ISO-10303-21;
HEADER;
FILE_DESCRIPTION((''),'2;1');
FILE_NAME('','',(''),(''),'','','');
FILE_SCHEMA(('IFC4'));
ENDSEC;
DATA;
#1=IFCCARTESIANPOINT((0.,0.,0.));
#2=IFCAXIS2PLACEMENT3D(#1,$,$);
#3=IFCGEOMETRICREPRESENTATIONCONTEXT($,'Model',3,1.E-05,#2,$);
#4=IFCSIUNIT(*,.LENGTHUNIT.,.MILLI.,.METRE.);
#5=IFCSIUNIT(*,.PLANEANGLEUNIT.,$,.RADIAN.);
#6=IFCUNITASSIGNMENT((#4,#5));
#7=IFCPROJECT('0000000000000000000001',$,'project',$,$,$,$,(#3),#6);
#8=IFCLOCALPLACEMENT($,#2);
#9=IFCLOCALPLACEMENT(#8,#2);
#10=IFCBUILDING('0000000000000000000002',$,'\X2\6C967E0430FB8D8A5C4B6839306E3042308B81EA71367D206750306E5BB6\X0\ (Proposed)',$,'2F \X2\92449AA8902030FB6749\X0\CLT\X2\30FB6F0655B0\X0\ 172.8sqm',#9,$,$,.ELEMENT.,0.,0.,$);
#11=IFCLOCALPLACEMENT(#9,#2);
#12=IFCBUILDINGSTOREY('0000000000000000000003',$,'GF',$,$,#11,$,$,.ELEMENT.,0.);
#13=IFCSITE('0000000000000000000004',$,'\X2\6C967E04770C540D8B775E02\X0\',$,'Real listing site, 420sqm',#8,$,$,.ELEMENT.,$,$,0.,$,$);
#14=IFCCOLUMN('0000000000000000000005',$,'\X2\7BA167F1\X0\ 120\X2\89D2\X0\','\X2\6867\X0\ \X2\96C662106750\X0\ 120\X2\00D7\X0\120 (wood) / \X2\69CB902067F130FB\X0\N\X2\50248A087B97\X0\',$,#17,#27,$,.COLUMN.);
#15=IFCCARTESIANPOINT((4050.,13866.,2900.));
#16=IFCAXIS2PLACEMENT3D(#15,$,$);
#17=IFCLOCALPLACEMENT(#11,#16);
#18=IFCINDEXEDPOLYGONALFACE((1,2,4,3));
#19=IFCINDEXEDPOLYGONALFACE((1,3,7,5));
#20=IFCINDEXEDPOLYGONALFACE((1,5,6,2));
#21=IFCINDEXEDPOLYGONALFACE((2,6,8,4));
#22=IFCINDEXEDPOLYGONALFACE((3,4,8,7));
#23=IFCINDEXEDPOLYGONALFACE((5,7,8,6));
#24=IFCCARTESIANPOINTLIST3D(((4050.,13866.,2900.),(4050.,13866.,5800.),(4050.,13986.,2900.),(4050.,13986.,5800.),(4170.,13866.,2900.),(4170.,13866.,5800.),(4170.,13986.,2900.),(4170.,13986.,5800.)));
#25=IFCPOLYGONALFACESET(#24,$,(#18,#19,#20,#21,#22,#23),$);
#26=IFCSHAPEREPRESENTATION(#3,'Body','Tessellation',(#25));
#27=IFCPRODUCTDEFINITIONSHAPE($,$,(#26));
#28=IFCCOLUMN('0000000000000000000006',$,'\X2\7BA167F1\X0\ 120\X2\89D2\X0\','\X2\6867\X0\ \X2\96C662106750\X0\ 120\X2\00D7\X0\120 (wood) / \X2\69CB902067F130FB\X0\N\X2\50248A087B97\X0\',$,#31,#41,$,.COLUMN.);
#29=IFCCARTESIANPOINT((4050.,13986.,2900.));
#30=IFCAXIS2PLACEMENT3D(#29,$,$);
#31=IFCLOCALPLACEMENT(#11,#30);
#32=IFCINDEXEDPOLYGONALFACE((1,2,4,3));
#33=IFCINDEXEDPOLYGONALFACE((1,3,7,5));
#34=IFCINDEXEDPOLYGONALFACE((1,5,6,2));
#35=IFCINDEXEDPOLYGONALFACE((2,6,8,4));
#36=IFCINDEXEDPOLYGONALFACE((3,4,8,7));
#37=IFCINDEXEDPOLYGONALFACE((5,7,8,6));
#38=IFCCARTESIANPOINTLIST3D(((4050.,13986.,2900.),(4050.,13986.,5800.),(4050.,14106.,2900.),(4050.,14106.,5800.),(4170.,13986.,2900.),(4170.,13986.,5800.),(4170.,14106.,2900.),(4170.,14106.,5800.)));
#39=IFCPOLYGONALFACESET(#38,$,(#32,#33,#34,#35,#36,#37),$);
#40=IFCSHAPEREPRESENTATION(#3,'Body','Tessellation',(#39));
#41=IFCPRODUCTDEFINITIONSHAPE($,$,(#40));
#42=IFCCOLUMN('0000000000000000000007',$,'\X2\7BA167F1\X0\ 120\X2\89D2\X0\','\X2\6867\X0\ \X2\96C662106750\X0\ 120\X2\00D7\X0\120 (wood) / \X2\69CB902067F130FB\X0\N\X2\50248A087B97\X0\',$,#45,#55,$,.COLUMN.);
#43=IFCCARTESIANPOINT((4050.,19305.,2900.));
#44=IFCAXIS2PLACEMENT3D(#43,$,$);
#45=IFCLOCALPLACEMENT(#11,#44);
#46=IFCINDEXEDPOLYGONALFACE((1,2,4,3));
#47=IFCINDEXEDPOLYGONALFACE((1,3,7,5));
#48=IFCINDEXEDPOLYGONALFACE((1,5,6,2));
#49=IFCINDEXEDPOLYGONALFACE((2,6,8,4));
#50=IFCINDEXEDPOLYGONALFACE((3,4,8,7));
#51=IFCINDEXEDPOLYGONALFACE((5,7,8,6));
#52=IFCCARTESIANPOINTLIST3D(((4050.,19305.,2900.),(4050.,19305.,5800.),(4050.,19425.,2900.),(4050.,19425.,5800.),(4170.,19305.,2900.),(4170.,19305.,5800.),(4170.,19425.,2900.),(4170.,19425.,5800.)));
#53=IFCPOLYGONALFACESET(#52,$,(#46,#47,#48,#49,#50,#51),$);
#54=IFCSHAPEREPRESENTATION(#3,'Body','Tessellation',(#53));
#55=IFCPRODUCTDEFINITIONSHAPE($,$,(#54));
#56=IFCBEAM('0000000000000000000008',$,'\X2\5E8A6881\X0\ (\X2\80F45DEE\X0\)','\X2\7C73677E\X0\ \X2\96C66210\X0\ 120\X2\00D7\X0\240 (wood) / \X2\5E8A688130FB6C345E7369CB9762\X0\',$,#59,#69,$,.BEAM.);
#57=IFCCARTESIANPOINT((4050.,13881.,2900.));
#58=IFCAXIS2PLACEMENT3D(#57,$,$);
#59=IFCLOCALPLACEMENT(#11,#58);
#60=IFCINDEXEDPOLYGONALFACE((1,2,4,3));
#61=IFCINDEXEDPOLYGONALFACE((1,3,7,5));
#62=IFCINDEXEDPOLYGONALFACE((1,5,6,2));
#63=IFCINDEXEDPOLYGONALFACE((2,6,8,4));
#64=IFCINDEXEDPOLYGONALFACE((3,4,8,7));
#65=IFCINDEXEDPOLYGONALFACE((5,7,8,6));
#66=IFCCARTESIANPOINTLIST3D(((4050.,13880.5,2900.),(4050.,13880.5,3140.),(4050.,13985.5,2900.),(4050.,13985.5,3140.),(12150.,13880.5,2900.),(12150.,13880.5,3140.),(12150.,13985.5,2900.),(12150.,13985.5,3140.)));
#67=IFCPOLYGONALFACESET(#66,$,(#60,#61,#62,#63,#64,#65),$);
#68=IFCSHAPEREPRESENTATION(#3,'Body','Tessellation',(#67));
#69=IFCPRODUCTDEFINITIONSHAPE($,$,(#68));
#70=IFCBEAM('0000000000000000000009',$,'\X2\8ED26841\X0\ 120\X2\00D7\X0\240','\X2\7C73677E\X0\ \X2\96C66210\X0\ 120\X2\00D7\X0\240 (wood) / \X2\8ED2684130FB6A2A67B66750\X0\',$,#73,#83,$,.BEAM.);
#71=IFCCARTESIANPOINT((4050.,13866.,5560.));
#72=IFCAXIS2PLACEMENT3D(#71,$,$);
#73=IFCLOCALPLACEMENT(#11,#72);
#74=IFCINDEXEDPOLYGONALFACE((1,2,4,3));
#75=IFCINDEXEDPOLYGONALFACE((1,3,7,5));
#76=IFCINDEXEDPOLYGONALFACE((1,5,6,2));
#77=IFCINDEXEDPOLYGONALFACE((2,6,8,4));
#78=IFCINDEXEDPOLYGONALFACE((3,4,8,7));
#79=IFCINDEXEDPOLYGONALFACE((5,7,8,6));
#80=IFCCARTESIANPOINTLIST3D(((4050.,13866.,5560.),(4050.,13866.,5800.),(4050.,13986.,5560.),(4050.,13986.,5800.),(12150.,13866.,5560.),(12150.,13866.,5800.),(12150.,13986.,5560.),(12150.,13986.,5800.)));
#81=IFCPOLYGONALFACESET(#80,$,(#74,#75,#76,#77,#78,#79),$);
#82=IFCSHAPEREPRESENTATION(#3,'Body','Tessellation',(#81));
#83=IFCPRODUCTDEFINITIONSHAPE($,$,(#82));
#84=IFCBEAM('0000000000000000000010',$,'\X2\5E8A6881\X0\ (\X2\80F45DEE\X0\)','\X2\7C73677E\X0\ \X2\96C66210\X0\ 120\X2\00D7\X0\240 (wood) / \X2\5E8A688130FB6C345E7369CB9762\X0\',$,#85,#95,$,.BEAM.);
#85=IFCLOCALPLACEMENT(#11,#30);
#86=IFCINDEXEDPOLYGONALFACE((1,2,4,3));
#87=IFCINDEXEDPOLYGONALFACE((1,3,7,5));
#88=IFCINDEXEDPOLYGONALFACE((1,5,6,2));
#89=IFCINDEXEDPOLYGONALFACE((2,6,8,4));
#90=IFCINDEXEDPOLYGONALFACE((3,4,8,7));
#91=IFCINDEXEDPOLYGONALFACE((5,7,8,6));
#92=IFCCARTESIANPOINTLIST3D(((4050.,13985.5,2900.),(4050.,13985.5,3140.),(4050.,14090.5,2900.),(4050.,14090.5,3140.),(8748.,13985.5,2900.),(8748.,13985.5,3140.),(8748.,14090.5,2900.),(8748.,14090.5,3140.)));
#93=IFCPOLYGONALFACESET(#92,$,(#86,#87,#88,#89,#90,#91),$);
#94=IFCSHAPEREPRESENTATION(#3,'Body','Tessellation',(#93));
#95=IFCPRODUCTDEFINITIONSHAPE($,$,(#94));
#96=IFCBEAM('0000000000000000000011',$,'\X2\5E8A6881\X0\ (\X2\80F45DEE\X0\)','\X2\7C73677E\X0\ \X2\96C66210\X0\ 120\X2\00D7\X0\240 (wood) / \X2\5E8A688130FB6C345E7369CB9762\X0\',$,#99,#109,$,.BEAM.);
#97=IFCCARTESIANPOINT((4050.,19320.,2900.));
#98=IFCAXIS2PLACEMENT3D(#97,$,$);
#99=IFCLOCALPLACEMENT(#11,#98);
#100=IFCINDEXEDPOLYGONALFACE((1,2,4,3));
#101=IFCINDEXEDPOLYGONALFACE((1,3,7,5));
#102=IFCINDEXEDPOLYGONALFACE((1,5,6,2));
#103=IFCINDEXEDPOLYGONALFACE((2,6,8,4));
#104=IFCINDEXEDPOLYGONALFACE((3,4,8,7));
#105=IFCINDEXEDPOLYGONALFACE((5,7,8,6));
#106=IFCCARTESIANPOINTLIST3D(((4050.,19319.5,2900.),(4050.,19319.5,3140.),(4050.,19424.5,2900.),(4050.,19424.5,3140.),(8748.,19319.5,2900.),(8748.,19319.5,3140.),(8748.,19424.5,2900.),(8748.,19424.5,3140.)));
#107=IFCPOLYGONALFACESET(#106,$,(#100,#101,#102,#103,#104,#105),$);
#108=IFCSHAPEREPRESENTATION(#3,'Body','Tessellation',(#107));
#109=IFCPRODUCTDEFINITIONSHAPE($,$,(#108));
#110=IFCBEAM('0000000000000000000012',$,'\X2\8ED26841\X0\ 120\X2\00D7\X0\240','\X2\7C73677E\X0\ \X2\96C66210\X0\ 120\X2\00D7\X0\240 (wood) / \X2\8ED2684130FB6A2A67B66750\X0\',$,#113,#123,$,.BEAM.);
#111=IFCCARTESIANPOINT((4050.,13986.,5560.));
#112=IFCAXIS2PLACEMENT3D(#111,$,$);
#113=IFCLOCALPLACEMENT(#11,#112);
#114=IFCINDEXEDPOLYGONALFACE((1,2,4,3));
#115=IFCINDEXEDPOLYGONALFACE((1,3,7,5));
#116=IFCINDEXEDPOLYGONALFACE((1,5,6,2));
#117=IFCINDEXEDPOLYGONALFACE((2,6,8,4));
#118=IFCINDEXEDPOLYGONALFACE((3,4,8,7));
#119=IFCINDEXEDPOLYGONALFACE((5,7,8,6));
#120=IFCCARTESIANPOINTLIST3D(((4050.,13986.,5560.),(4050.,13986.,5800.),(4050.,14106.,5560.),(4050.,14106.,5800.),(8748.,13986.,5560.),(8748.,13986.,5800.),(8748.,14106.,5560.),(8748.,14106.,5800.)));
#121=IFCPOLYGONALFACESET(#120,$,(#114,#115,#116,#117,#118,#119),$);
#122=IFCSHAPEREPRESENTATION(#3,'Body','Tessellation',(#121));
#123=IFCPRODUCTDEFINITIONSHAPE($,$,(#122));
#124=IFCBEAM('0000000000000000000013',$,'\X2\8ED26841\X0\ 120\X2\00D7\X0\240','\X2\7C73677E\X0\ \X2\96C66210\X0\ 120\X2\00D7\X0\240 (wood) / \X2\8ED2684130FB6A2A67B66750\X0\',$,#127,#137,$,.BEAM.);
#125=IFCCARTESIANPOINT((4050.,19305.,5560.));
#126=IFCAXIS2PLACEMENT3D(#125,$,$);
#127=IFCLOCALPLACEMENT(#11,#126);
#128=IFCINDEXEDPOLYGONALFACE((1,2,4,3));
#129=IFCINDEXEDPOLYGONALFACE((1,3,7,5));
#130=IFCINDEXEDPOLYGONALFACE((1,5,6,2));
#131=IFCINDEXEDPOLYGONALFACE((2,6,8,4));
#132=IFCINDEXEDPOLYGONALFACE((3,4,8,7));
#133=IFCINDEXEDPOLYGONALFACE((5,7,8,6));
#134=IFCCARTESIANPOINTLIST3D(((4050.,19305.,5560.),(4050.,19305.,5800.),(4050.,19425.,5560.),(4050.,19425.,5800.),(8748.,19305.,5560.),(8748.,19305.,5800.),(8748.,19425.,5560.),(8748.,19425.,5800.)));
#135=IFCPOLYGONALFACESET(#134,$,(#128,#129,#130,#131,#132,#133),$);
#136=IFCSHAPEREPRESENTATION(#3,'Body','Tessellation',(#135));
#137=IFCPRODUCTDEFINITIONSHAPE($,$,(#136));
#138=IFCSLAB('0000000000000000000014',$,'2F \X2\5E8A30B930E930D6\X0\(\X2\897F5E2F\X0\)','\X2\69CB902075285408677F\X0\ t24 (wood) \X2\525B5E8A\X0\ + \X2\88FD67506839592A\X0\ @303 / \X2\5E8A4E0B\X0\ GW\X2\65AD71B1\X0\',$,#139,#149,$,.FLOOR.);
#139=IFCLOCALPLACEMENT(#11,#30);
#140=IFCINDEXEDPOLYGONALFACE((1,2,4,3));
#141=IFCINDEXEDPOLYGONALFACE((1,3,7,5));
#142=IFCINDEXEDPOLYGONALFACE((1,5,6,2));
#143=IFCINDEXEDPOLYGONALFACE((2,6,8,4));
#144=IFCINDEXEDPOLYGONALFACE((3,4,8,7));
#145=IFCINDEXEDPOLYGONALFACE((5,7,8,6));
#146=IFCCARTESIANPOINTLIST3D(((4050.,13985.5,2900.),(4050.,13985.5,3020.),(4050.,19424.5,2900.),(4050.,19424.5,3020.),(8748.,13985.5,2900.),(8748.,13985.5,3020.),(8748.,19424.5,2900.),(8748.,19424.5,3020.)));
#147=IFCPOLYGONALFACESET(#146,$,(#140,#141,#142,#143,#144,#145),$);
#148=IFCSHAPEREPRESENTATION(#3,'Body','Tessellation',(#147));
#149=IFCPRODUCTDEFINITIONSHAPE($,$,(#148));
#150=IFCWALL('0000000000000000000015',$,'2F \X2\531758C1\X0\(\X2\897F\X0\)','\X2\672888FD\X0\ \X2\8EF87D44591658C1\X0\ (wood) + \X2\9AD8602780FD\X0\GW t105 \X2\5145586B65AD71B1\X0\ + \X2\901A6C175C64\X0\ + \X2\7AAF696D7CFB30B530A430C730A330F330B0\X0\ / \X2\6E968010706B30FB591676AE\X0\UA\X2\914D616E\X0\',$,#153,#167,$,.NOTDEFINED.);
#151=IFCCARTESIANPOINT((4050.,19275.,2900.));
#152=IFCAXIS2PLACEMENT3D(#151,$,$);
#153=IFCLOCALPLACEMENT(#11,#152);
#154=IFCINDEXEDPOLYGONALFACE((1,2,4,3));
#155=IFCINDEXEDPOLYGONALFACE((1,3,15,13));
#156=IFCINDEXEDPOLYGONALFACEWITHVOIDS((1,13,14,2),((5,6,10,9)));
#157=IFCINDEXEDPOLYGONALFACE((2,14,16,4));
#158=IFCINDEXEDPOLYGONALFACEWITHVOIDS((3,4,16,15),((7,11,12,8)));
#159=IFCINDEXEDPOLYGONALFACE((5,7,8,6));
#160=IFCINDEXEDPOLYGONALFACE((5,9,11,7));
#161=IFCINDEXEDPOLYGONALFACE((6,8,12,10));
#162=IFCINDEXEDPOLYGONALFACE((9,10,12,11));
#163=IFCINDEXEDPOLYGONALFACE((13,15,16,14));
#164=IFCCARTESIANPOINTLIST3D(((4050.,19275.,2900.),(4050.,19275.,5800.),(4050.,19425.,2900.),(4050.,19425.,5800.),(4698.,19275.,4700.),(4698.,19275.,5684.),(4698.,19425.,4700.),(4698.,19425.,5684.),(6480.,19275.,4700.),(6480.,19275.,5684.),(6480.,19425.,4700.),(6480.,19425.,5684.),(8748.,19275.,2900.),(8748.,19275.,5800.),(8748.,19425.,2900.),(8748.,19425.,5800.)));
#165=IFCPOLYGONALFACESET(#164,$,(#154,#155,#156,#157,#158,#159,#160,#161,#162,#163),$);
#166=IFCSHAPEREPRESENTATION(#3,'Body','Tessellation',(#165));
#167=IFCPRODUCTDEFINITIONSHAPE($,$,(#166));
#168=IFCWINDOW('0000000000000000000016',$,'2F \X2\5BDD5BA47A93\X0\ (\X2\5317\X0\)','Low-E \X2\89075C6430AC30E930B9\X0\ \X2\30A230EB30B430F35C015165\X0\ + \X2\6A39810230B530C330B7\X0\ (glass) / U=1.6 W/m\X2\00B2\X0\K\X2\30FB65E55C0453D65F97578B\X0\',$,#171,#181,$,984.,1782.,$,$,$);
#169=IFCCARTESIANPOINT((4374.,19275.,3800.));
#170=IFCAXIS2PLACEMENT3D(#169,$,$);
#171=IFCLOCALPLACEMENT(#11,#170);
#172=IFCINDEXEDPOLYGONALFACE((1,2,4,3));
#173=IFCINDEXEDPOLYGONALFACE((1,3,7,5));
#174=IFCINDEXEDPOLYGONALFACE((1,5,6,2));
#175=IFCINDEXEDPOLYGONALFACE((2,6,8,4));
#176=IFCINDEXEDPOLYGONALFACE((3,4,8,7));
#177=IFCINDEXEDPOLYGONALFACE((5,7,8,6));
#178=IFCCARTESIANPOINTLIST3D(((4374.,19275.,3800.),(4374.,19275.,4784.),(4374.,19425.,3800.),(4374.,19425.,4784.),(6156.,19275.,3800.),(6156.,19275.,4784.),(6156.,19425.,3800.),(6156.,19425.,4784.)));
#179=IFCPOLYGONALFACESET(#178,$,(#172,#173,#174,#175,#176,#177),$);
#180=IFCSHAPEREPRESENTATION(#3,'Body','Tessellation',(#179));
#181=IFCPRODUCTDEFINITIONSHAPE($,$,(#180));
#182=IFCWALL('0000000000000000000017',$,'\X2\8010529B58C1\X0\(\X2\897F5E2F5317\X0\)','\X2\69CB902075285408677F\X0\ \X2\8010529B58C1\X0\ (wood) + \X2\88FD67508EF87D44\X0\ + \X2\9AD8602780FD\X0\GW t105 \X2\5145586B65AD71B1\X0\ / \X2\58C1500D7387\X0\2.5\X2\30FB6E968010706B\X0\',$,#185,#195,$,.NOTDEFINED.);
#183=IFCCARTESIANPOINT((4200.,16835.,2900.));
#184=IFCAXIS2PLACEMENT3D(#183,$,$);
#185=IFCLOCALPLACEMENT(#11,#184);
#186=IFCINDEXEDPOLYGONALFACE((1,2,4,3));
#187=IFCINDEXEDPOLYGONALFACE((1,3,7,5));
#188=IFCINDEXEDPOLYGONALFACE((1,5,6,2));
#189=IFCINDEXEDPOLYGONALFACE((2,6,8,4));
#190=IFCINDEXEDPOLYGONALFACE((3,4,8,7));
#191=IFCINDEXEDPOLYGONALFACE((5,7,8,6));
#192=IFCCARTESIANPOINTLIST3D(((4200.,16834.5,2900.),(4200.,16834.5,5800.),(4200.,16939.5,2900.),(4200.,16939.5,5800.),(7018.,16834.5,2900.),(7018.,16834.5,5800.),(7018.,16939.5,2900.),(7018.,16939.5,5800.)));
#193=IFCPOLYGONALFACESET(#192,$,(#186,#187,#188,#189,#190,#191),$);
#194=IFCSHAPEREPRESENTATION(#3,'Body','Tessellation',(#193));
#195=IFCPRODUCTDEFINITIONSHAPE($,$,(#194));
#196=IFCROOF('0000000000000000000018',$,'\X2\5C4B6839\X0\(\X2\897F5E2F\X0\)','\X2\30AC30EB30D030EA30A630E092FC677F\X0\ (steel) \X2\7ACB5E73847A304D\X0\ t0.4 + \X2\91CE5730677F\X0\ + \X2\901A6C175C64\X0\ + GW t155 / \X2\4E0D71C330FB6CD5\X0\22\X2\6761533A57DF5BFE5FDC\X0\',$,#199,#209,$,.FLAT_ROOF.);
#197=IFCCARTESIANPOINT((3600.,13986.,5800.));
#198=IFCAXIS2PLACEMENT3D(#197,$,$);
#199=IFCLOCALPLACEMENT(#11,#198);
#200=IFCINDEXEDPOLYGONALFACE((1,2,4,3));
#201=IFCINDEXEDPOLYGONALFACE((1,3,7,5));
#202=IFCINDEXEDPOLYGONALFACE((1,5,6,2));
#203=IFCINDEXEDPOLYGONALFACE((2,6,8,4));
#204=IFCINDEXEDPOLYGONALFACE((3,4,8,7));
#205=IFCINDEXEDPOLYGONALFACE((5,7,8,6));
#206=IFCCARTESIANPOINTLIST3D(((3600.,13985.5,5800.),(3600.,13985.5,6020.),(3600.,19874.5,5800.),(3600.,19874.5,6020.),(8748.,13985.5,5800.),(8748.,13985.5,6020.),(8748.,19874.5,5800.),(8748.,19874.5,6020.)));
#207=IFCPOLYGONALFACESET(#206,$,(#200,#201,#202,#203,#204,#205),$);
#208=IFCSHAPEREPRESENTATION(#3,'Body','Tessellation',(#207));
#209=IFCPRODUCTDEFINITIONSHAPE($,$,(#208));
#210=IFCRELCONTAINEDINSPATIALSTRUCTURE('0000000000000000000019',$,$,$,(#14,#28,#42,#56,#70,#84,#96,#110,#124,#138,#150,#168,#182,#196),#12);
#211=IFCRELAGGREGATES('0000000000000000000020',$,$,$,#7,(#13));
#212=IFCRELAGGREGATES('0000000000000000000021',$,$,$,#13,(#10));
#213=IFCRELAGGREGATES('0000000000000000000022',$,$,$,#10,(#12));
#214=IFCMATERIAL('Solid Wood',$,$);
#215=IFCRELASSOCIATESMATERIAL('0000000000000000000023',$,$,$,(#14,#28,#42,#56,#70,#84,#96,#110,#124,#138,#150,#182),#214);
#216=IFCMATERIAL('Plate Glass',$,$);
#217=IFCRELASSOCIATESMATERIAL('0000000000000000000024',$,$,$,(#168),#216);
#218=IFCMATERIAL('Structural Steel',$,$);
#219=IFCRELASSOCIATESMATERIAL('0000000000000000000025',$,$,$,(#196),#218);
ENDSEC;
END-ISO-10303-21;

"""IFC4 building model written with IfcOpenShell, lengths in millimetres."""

from ifc_helpers import new_model, si_unit, frame, frame_2d, origin, place, context, project, spatial, rectangle, extrude, material, element, fill, save


model = new_model("IFC4")

# Units and contexts
model_context = context("Model", 3, precision=1e-05, world=origin())
ifc_project = project(units=[si_unit("LENGTHUNIT", "METRE", prefix="MILLI"), si_unit("PLANEANGLEUNIT", "RADIAN")], contexts=[model_context])

# Site, building, storey
site_placement = place(None, origin())
site = spatial("IfcSite", under=ifc_project, at=site_placement, Name="沖縄県名護市", ObjectType="Real listing site, 420sqm", CompositionType="ELEMENT", RefElevation=0.0)
building_placement = place(site_placement, origin())
building = spatial("IfcBuilding", under=site, at=building_placement, Name="沖縄・越屋根のある自然素材の家 (Proposed)", ObjectType="2F 鉄骨造・杉CLT・漆喰 172.8sqm", CompositionType="ELEMENT", ElevationOfRefHeight=0.0, ElevationOfTerrain=0.0)
storey_placement = place(building_placement, origin())
storey = spatial("IfcBuildingStorey", under=building, at=storey_placement, Name="GF", CompositionType="ELEMENT", Elevation=0.0)

# Columns
ifc_material_1 = material(Name="Solid Wood")
column_1_placement = place(storey_placement, frame((4050.0, 13866.0, 2900.0)))
element("IfcColumn", 1, at=column_1_placement, inside=storey, material=ifc_material_1, Name="管柱 120角", Description="桧 集成材 120×120 (wood) / 構造柱・N値計算", PredefinedType="COLUMN", context=model_context, shape_type="SweptSolid", body=[
    extrude(rectangle(XDim=120.0, YDim=120.0, at=frame_2d((60.0, 60.0))), frame((4050.0, 13866.0, 2900.0)), (0.0, 0.0, 1.0), 2900.0),
])
column_2_placement = place(storey_placement, frame((4050.0, 13986.0, 2900.0)))
element("IfcColumn", 2, at=column_2_placement, inside=storey, material=ifc_material_1, Name="管柱 120角", Description="桧 集成材 120×120 (wood) / 構造柱・N値計算", PredefinedType="COLUMN", context=model_context, shape_type="SweptSolid", body=[
    extrude(rectangle(XDim=120.0, YDim=120.0, at=frame_2d((60.0, 60.0))), frame((4050.0, 13986.0, 2900.0)), (0.0, 0.0, 1.0), 2900.0),
])
column_3_placement = place(storey_placement, frame((4050.0, 19305.0, 2900.0)))
element("IfcColumn", 3, at=column_3_placement, inside=storey, material=ifc_material_1, Name="管柱 120角", Description="桧 集成材 120×120 (wood) / 構造柱・N値計算", PredefinedType="COLUMN", context=model_context, shape_type="SweptSolid", body=[
    extrude(rectangle(XDim=120.0, YDim=120.0, at=frame_2d((60.0, 60.0))), frame((4050.0, 19305.0, 2900.0)), (0.0, 0.0, 1.0), 2900.0),
])

# Beams
beam_1_placement = place(storey_placement, frame((4050.0, 13881.0, 2900.0)))
element("IfcBeam", 4, at=beam_1_placement, inside=storey, material=ifc_material_1, Name="床梁 (胴差)", Description="米松 集成 120×240 (wood) / 床梁・水平構面", PredefinedType="BEAM", context=model_context, shape_type="SweptSolid", body=[
    extrude(rectangle(XDim=8100.0, YDim=105.0, at=frame_2d((4050.0, 52.0))), frame((4050.0, 13881.0, 2900.0)), (0.0, 0.0, 1.0), 240.0),
])
beam_2_placement = place(storey_placement, frame((4050.0, 13866.0, 5560.0)))
element("IfcBeam", 5, at=beam_2_placement, inside=storey, material=ifc_material_1, Name="軒桁 120×240", Description="米松 集成 120×240 (wood) / 軒桁・横架材", PredefinedType="BEAM", context=model_context, shape_type="SweptSolid", body=[
    extrude(rectangle(XDim=8100.0, YDim=120.0, at=frame_2d((4050.0, 60.0))), frame((4050.0, 13866.0, 5560.0)), (0.0, 0.0, 1.0), 240.0),
])
beam_3_placement = place(storey_placement, frame((4050.0, 13986.0, 2900.0)))
element("IfcBeam", 6, at=beam_3_placement, inside=storey, material=ifc_material_1, Name="床梁 (胴差)", Description="米松 集成 120×240 (wood) / 床梁・水平構面", PredefinedType="BEAM", context=model_context, shape_type="SweptSolid", body=[
    extrude(rectangle(XDim=4698.0, YDim=105.0, at=frame_2d((2349.0, 52.0))), frame((4050.0, 13986.0, 2900.0)), (0.0, 0.0, 1.0), 240.0),
])
beam_4_placement = place(storey_placement, frame((4050.0, 19320.0, 2900.0)))
element("IfcBeam", 7, at=beam_4_placement, inside=storey, material=ifc_material_1, Name="床梁 (胴差)", Description="米松 集成 120×240 (wood) / 床梁・水平構面", PredefinedType="BEAM", context=model_context, shape_type="SweptSolid", body=[
    extrude(rectangle(XDim=4698.0, YDim=105.0, at=frame_2d((2349.0, 52.0))), frame((4050.0, 19320.0, 2900.0)), (0.0, 0.0, 1.0), 240.0),
])
beam_5_placement = place(storey_placement, frame((4050.0, 13986.0, 5560.0)))
element("IfcBeam", 8, at=beam_5_placement, inside=storey, material=ifc_material_1, Name="軒桁 120×240", Description="米松 集成 120×240 (wood) / 軒桁・横架材", PredefinedType="BEAM", context=model_context, shape_type="SweptSolid", body=[
    extrude(rectangle(XDim=4698.0, YDim=120.0, at=frame_2d((2349.0, 60.0))), frame((4050.0, 13986.0, 5560.0)), (0.0, 0.0, 1.0), 240.0),
])
beam_6_placement = place(storey_placement, frame((4050.0, 19305.0, 5560.0)))
element("IfcBeam", 9, at=beam_6_placement, inside=storey, material=ifc_material_1, Name="軒桁 120×240", Description="米松 集成 120×240 (wood) / 軒桁・横架材", PredefinedType="BEAM", context=model_context, shape_type="SweptSolid", body=[
    extrude(rectangle(XDim=4698.0, YDim=120.0, at=frame_2d((2349.0, 60.0))), frame((4050.0, 19305.0, 5560.0)), (0.0, 0.0, 1.0), 240.0),
])

# Slab
slab_placement = place(storey_placement, frame((4050.0, 13986.0, 2900.0)))
element("IfcSlab", 10, at=slab_placement, inside=storey, material=ifc_material_1, Name="2F 床スラブ(西帯)", Description="構造用合板 t24 (wood) 剛床 + 製材根太 @303 / 床下 GW断熱", PredefinedType="FLOOR", context=model_context, shape_type="SweptSolid", body=[
    extrude(rectangle(XDim=4698.0, YDim=5439.0, at=frame_2d((2349.0, 2719.0))), frame((4050.0, 13986.0, 2900.0)), (0.0, 0.0, 1.0), 120.0),
])

# Wall, opening, window
wall_1_placement = place(storey_placement, frame((4050.0, 19275.0, 2900.0)))
wall_1 = element("IfcWall", 11, at=wall_1_placement, inside=storey, material=ifc_material_1, Name="2F 北壁(西)", Description="木製 軸組外壁 (wood) + 高性能GW t105 充填断熱 + 通気層 + 窯業系サイディング / 準耐火・外皮UA配慮", PredefinedType="NOTDEFINED", context=model_context, shape_type="SweptSolid", body=[
    extrude(rectangle(XDim=4698.0, YDim=150.0, at=frame_2d((2349.0, 75.0))), frame((4050.0, 19275.0, 2900.0)), (0.0, 0.0, 1.0), 2900.0),
])
opening_placement = place(storey_placement, frame((4374.0, 19275.0, 3800.0)))
opening = element("IfcOpeningElement", 12, at=opening_placement, cuts=wall_1, PredefinedType="NOTDEFINED", context=model_context, shape_type="SweptSolid", body=[
    extrude(rectangle(XDim=1782.0, YDim=150.0, at=frame_2d((891.0, 75.0))), frame((4374.0, 19275.0, 3800.0)), (0.0, 0.0, 1.0), 984.0),
])
ifc_material_2 = material(Name="Plate Glass")
window_placement = place(storey_placement, frame((4374.0, 19275.0, 3800.0)))
window = element("IfcWindow", 13, at=window_placement, inside=storey, material=ifc_material_2, Name="2F 寝室窓 (北)", Description="Low-E 複層ガラス アルゴン封入 + 樹脂サッシ (glass) / U=1.6 W/m²K・日射取得型", OverallHeight=984.0, OverallWidth=1782.0, context=model_context, shape_type="SweptSolid", body=[
    extrude(rectangle(XDim=1782.0, YDim=150.0, at=frame_2d((891.0, 75.0))), frame((4374.0, 19275.0, 3800.0)), (0.0, 0.0, 1.0), 984.0),
])
fill(opening, window)

# Wall
wall_2_placement = place(storey_placement, frame((4200.0, 16835.0, 2900.0)))
element("IfcWall", 14, at=wall_2_placement, inside=storey, material=ifc_material_1, Name="耐力壁(西帯北)", Description="構造用合板 耐力壁 (wood) + 製材軸組 + 高性能GW t105 充填断熱 / 壁倍率2.5・準耐火", PredefinedType="NOTDEFINED", context=model_context, shape_type="SweptSolid", body=[
    extrude(rectangle(XDim=2818.0, YDim=105.0, at=frame_2d((1409.0, 52.0))), frame((4200.0, 16835.0, 2900.0)), (0.0, 0.0, 1.0), 2900.0),
])

# Roof
ifc_material_3 = material(Name="Structural Steel")
for number, where, name in (
    (15, (3600.0, 13986.0, 5800.0), "屋根(西帯)"),
):
    element("IfcRoof", number, at=place(storey_placement, frame(where)), inside=storey, material=ifc_material_3, Name=name, Description="ガルバリウム鋼板 (steel) 立平葺き t0.4 + 野地板 + 通気層 + GW t155 / 不燃・法22条区域対応", PredefinedType="FLAT_ROOF", context=model_context, shape_type="SweptSolid", body=[
        extrude(rectangle(XDim=5148.0, YDim=5889.0, at=frame_2d((2574.0, 2944.0))), frame((3600.0, 13986.0, 5800.0)), (0.0, 0.0, 1.0), 220.0),
    ])

save(model, "model.ifc")
